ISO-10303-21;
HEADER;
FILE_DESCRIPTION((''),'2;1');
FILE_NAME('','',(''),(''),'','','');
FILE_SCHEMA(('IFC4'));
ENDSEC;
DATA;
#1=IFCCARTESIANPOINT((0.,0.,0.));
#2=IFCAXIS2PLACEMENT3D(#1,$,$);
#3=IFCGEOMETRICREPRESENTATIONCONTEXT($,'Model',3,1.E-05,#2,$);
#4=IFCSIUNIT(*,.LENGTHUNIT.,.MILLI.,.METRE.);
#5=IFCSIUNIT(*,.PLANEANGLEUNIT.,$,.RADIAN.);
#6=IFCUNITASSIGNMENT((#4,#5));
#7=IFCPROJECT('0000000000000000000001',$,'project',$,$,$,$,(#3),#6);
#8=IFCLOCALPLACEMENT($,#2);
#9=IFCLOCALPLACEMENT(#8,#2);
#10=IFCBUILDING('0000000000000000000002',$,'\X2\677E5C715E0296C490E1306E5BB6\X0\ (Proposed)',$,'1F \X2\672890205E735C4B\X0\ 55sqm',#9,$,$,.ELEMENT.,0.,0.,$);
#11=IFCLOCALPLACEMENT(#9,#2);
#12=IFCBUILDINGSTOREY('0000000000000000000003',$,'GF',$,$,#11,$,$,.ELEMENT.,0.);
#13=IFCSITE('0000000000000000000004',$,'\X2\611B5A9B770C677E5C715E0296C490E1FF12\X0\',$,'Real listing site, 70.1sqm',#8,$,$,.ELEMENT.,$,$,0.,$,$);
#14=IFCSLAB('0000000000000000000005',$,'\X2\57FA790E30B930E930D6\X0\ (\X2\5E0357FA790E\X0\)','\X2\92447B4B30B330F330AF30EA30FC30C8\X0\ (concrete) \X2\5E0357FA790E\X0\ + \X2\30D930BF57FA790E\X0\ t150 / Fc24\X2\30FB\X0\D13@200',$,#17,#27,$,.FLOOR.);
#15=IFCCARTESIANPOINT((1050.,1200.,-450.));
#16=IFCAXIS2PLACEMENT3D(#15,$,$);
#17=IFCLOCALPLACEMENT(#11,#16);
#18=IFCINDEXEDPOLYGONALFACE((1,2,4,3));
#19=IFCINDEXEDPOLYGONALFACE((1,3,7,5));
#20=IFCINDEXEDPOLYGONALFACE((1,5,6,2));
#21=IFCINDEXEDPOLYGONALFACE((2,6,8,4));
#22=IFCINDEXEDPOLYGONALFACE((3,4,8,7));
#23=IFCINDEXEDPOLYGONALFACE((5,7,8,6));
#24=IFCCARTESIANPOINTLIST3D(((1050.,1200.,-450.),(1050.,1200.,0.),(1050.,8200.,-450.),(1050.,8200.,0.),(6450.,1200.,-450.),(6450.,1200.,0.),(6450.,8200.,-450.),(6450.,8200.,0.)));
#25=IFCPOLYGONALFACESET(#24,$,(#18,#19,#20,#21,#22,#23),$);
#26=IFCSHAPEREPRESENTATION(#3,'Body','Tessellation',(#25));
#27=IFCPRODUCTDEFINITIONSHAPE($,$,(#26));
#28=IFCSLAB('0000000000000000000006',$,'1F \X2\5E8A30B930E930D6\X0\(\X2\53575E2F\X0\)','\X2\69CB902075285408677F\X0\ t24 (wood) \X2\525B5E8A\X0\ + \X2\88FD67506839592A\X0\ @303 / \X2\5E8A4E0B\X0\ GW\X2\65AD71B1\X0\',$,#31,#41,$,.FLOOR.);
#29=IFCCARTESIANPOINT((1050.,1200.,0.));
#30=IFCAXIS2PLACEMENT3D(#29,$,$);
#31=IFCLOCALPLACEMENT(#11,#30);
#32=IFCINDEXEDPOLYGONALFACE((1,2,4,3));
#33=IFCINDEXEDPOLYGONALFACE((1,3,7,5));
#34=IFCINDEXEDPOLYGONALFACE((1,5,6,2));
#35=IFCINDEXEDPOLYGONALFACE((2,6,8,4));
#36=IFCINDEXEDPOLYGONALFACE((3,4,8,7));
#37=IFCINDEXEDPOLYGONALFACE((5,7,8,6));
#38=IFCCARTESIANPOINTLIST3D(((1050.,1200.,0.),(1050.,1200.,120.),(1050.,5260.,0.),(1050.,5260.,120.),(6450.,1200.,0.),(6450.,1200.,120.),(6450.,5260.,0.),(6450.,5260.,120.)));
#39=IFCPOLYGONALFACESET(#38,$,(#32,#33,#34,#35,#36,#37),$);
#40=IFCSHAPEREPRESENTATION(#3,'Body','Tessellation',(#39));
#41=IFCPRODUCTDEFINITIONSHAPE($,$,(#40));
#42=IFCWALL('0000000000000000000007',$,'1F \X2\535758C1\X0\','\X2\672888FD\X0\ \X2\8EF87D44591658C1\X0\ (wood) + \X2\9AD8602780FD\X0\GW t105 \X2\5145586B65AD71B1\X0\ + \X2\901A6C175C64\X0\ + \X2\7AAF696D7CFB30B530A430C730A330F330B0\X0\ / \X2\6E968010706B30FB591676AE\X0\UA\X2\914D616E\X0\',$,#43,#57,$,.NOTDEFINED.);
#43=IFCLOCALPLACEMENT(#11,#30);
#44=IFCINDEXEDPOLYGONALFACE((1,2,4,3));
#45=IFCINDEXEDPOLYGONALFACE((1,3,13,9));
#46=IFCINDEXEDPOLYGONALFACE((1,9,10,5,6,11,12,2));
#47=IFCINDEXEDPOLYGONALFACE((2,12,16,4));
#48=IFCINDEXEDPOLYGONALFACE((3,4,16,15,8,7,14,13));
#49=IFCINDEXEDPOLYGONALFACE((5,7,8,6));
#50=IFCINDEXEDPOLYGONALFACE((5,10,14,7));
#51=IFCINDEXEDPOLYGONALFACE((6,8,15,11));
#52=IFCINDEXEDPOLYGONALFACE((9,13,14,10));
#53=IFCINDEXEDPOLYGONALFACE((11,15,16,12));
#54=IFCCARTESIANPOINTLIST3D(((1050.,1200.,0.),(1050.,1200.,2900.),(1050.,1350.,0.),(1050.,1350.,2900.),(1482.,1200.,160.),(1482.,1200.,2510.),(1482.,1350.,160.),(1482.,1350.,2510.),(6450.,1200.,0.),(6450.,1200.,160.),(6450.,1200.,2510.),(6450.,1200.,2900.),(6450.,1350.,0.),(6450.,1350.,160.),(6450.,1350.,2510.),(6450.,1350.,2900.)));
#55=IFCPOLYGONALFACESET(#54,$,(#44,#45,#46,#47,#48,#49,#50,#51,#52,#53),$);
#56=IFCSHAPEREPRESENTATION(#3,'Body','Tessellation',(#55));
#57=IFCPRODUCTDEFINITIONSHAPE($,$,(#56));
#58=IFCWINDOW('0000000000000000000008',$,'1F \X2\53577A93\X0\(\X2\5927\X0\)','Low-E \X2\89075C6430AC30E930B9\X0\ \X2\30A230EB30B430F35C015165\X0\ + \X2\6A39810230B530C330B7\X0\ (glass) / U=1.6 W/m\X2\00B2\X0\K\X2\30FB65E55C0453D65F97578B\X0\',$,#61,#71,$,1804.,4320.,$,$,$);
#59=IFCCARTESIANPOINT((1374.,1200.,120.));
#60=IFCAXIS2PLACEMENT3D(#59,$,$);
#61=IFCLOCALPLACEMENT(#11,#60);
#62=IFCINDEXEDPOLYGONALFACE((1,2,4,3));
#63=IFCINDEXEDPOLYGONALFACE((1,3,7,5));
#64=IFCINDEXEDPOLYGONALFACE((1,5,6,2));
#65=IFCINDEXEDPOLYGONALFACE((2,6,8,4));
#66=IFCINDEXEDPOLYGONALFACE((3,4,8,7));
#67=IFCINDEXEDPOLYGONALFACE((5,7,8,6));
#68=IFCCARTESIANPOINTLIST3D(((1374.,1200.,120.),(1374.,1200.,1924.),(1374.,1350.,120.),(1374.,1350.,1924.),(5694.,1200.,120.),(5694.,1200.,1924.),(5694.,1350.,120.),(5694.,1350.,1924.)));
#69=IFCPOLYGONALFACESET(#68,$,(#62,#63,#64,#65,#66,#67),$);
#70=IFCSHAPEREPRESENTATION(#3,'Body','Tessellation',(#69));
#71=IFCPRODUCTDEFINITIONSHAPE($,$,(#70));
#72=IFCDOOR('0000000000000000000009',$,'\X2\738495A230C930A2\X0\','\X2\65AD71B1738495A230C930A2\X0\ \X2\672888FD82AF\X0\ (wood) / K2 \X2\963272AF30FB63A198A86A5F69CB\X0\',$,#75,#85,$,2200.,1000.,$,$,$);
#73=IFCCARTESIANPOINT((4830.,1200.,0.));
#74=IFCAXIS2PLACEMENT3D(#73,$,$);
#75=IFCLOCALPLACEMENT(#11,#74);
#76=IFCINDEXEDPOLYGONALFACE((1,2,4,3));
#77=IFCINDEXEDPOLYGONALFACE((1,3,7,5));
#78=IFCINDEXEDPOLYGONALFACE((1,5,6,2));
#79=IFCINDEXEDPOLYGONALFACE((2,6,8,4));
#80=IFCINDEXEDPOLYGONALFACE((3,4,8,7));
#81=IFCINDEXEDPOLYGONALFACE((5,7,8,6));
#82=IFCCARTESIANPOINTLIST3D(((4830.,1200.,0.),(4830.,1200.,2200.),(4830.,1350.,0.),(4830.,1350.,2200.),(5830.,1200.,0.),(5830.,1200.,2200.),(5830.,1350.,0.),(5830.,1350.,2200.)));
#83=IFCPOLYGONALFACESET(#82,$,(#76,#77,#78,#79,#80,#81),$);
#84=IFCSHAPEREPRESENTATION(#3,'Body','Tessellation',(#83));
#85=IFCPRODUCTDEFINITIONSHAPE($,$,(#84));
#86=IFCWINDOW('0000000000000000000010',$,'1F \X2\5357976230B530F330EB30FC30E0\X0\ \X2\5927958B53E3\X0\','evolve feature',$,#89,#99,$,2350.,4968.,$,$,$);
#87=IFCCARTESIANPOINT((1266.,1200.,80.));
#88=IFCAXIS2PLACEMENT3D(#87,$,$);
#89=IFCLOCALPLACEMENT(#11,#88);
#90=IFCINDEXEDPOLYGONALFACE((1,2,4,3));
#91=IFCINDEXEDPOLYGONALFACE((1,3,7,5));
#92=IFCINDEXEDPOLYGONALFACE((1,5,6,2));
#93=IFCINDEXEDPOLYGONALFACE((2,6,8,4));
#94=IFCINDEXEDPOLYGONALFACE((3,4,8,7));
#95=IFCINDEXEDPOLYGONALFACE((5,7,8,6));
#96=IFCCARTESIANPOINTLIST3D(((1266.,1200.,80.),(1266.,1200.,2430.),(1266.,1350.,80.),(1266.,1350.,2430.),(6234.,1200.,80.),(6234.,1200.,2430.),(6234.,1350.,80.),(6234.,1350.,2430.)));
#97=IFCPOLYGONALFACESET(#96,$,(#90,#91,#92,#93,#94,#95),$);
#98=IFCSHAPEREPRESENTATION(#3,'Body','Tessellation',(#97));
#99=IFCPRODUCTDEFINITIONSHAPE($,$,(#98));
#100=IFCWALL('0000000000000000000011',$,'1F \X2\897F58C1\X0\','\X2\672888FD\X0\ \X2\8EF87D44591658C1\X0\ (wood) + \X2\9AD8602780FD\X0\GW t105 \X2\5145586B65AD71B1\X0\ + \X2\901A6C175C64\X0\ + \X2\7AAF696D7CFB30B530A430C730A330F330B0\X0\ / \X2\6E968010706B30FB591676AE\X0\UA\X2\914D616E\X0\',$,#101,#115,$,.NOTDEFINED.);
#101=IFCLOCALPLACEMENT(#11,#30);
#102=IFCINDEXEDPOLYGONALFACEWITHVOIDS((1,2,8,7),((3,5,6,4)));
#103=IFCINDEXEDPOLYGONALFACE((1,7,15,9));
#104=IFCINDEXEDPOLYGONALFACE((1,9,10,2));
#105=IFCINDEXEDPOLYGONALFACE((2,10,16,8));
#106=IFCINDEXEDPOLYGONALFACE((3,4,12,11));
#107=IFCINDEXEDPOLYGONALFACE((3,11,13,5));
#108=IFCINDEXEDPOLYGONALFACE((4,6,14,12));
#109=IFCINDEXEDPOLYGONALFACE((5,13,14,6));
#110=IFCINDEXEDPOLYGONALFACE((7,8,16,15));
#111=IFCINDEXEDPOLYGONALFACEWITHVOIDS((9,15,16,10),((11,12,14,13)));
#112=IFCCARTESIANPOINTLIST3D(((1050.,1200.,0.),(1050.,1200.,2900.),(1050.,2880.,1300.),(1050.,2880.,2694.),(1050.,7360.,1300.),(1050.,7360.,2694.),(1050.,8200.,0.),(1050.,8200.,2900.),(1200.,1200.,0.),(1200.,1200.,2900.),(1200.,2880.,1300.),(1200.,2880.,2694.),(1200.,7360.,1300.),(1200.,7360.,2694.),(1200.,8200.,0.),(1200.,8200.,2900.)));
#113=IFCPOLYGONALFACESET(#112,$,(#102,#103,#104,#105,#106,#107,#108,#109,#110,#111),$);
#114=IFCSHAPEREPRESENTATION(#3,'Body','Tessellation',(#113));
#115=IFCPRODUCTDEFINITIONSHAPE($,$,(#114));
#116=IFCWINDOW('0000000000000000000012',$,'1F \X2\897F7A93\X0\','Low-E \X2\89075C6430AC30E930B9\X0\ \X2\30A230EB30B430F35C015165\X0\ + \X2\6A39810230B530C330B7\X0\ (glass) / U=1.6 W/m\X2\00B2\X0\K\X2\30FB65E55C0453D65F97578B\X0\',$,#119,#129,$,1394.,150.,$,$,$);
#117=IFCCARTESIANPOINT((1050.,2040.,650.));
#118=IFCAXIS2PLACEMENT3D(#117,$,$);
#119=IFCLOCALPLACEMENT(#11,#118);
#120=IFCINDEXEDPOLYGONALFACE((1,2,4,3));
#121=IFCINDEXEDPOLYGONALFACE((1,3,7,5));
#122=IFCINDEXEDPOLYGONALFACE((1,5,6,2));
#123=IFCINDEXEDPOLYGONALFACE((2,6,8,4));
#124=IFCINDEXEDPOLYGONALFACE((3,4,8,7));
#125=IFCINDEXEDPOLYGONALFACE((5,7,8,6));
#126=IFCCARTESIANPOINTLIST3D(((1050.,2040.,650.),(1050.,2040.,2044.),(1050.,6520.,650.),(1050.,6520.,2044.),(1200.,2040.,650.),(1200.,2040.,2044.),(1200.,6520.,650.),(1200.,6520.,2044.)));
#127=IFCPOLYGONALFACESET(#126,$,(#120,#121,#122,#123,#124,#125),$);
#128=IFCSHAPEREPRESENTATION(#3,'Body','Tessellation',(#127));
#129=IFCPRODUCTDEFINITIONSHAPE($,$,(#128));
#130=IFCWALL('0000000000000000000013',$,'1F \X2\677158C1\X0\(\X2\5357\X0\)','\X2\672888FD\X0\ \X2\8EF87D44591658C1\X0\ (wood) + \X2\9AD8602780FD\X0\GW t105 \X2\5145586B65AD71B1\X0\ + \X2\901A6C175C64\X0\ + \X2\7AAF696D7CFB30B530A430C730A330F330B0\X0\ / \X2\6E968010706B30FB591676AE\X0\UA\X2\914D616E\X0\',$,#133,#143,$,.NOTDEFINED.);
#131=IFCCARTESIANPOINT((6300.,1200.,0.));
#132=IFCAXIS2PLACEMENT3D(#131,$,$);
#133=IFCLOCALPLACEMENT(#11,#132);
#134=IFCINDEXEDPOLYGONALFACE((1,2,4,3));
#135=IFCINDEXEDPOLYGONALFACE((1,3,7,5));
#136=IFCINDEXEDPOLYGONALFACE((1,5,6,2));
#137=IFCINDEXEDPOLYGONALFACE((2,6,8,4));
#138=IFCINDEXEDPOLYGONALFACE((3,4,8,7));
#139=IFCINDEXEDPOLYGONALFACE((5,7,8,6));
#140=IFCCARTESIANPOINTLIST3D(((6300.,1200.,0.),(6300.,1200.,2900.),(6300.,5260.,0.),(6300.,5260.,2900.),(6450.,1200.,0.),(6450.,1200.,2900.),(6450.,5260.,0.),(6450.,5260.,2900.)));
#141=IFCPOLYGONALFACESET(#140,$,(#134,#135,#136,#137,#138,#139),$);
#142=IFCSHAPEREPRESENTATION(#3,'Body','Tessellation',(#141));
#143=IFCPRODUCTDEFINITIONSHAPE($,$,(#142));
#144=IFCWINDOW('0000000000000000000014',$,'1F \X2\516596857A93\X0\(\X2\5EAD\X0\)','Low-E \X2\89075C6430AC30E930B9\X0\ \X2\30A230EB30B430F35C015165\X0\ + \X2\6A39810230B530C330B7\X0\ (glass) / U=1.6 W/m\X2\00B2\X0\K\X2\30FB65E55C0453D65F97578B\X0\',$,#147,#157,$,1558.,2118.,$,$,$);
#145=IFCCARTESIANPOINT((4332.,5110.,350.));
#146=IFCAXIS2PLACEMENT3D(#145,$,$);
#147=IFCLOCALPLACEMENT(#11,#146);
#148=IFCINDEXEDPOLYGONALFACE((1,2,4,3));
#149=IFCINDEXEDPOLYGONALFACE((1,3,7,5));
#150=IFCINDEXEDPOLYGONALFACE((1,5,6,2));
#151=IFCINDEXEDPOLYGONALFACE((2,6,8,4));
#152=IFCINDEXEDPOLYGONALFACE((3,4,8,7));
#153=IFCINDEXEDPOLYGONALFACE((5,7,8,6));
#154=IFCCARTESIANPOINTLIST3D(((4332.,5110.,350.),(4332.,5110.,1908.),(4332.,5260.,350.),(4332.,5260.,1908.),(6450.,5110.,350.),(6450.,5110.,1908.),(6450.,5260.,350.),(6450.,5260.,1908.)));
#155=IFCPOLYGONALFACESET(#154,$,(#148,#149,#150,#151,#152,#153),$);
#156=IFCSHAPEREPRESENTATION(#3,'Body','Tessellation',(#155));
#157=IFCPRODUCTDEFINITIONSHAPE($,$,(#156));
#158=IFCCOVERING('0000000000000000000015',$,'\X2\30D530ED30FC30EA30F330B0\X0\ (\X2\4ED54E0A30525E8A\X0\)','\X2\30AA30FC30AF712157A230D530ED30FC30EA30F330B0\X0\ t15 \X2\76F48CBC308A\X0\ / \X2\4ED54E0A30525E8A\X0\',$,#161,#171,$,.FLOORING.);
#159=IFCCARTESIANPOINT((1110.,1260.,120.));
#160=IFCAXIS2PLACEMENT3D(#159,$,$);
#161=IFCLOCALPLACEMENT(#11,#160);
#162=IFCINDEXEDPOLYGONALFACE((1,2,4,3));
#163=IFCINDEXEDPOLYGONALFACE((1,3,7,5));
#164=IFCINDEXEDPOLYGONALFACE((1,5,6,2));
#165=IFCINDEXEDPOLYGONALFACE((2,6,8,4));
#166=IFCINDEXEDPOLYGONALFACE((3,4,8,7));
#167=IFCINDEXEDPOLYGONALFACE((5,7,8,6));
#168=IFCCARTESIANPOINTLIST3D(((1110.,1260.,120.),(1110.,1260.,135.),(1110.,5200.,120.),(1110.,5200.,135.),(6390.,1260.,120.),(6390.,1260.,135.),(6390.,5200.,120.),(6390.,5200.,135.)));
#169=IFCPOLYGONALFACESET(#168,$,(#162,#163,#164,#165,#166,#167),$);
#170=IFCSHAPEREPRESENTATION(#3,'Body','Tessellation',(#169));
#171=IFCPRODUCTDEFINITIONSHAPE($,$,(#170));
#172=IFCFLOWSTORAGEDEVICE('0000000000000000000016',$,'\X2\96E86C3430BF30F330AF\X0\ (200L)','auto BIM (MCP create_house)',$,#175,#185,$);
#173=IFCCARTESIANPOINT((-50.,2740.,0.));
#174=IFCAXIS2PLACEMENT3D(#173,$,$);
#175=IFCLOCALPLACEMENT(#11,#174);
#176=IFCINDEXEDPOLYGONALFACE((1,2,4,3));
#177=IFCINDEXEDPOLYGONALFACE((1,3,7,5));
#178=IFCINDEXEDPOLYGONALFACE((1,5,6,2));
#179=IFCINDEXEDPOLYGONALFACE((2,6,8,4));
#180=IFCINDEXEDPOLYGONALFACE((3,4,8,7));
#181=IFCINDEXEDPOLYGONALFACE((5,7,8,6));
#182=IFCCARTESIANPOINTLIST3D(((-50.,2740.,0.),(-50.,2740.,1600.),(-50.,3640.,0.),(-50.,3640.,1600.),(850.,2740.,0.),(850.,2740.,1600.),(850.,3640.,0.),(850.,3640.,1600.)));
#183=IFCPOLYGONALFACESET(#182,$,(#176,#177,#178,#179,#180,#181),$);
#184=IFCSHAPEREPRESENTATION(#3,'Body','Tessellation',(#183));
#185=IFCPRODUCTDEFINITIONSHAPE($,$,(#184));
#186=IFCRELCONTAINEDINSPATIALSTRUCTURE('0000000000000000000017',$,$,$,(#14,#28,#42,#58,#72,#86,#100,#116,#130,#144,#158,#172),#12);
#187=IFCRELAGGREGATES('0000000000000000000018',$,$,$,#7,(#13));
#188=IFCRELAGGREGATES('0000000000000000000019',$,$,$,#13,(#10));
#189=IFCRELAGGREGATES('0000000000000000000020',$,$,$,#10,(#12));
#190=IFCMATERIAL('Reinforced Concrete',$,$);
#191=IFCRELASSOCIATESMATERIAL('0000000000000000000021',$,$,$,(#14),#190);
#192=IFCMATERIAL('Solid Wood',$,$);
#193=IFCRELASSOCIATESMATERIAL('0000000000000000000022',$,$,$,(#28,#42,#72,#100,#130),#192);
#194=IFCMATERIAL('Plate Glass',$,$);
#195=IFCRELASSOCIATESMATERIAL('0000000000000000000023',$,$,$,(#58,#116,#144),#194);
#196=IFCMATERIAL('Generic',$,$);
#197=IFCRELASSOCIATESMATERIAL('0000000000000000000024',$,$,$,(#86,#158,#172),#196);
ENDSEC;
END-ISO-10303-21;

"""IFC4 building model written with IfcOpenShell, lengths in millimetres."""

from ifc_helpers import new_model, si_unit, frame, frame_2d, origin, place, context, project, spatial, rectangle, extrude, material, element, fill, save


model = new_model("IFC4")

# Units and contexts
model_context = context("Model", 3, precision=1e-05, world=origin())
ifc_project = project(units=[si_unit("LENGTHUNIT", "METRE", prefix="MILLI"), si_unit("PLANEANGLEUNIT", "RADIAN")], contexts=[model_context])

# Site, building, storey
site_placement = place(None, origin())
site = spatial("IfcSite", under=ifc_project, at=site_placement, Name="愛媛県松山市雄郡２", ObjectType="Real listing site, 70.1sqm", CompositionType="ELEMENT", RefElevation=0.0)
building_placement = place(site_placement, origin())
building = spatial("IfcBuilding", under=site, at=building_placement, Name="松山市雄郡の家 (Proposed)", ObjectType="1F 木造平屋 55sqm", CompositionType="ELEMENT", ElevationOfRefHeight=0.0, ElevationOfTerrain=0.0)
storey_placement = place(building_placement, origin())
storey = spatial("IfcBuildingStorey", under=building, at=storey_placement, Name="GF", CompositionType="ELEMENT", Elevation=0.0)

# Slabs
ifc_material_1 = material(Name="Reinforced Concrete")
slab_1_placement = place(storey_placement, frame((1050.0, 1200.0, -450.0)))
element("IfcSlab", 1, at=slab_1_placement, inside=storey, material=ifc_material_1, Name="基礎スラブ (布基礎)", Description="鉄筋コンクリート (concrete) 布基礎 + ベタ基礎 t150 / Fc24・D13@200", PredefinedType="FLOOR", context=model_context, shape_type="SweptSolid", body=[
    extrude(rectangle(XDim=5400.0, YDim=7000.0, at=frame_2d((2700.0, 3500.0))), frame((1050.0, 1200.0, -450.0)), (0.0, 0.0, 1.0), 450.0),
])
ifc_material_2 = material(Name="Solid Wood")
slab_2_placement = place(storey_placement, frame((1050.0, 1200.0, 0.0)))
element("IfcSlab", 2, at=slab_2_placement, inside=storey, material=ifc_material_2, Name="1F 床スラブ(南帯)", Description="構造用合板 t24 (wood) 剛床 + 製材根太 @303 / 床下 GW断熱", PredefinedType="FLOOR", context=model_context, shape_type="SweptSolid", body=[
    extrude(rectangle(XDim=5400.0, YDim=4060.0, at=frame_2d((2700.0, 2030.0))), frame((1050.0, 1200.0, 0.0)), (0.0, 0.0, 1.0), 120.0),
])

# Wall, openings, windows, door
wall_1_placement = place(storey_placement, frame((1050.0, 1200.0, 0.0)))
wall_1 = element("IfcWall", 3, at=wall_1_placement, inside=storey, material=ifc_material_2, Name="1F 南壁", Description="木製 軸組外壁 (wood) + 高性能GW t105 充填断熱 + 通気層 + 窯業系サイディング / 準耐火・外皮UA配慮", PredefinedType="NOTDEFINED", context=model_context, shape_type="SweptSolid", body=[
    extrude(rectangle(XDim=5400.0, YDim=150.0, at=frame_2d((2700.0, 75.0))), frame((1050.0, 1200.0, 0.0)), (0.0, 0.0, 1.0), 2900.0),
])
opening_1_placement = place(storey_placement, frame((1374.0, 1200.0, 120.0)))
opening_1 = element("IfcOpeningElement", 4, at=opening_1_placement, cuts=wall_1, PredefinedType="NOTDEFINED", context=model_context, shape_type="SweptSolid", body=[
    extrude(rectangle(XDim=4320.0, YDim=150.0, at=frame_2d((2160.0, 75.0))), frame((1374.0, 1200.0, 120.0)), (0.0, 0.0, 1.0), 1804.0),
])
opening_2_placement = place(storey_placement, frame((4830.0, 1200.0, 0.0)))
opening_2 = element("IfcOpeningElement", 5, at=opening_2_placement, cuts=wall_1, PredefinedType="NOTDEFINED", context=model_context, shape_type="SweptSolid", body=[
    extrude(rectangle(XDim=1000.0, YDim=150.0, at=frame_2d((500.0, 75.0))), frame((4830.0, 1200.0, 0.0)), (0.0, 0.0, 1.0), 2200.0),
])
opening_3_placement = place(storey_placement, frame((1266.0, 1200.0, 80.0)))
opening_3 = element("IfcOpeningElement", 6, at=opening_3_placement, cuts=wall_1, PredefinedType="NOTDEFINED", context=model_context, shape_type="SweptSolid", body=[
    extrude(rectangle(XDim=4968.0, YDim=150.0, at=frame_2d((2484.0, 75.0))), frame((1266.0, 1200.0, 80.0)), (0.0, 0.0, 1.0), 2350.0),
])
ifc_material_3 = material(Name="Plate Glass")
window_1_placement = place(storey_placement, frame((1374.0, 1200.0, 120.0)))
window_1 = element("IfcWindow", 7, at=window_1_placement, inside=storey, material=ifc_material_3, Name="1F 南窓(大)", Description="Low-E 複層ガラス アルゴン封入 + 樹脂サッシ (glass) / U=1.6 W/m²K・日射取得型", OverallHeight=1804.0, OverallWidth=4320.0, context=model_context, shape_type="SweptSolid", body=[
    extrude(rectangle(XDim=4320.0, YDim=150.0, at=frame_2d((2160.0, 75.0))), frame((1374.0, 1200.0, 120.0)), (0.0, 0.0, 1.0), 1804.0),
])
fill(opening_1, window_1)
door_1_placement = place(storey_placement, frame((4830.0, 1200.0, 0.0)))
door_1 = element("IfcDoor", 8, at=door_1_placement, inside=storey, material=ifc_material_2, Name="玄関ドア", Description="断熱玄関ドア 木製芯 (wood) / K2 防犯・採風機構", OverallHeight=2200.0, OverallWidth=1000.0, context=model_context, shape_type="SweptSolid", body=[
    extrude(rectangle(XDim=1000.0, YDim=150.0, at=frame_2d((500.0, 75.0))), frame((4830.0, 1200.0, 0.0)), (0.0, 0.0, 1.0), 2200.0),
])
fill(opening_2, door_1)
ifc_material_4 = material(Name="Generic")
window_2_placement = place(storey_placement, frame((1266.0, 1200.0, 80.0)))
window_2 = element("IfcWindow", 9, at=window_2_placement, inside=storey, material=ifc_material_4, Name="1F 南面サンルーム 大開口", Description="evolve feature", OverallHeight=2350.0, OverallWidth=4968.0, context=model_context, shape_type="SweptSolid", body=[
    extrude(rectangle(XDim=4968.0, YDim=150.0, at=frame_2d((2484.0, 75.0))), frame((1266.0, 1200.0, 80.0)), (0.0, 0.0, 1.0), 2350.0),
])
fill(opening_3, window_2)

# Walls, openings, windows
wall_2_placement = place(storey_placement, frame((1050.0, 1200.0, 0.0)))
wall_2 = element("IfcWall", 10, at=wall_2_placement, inside=storey, material=ifc_material_2, Name="1F 西壁", Description="木製 軸組外壁 (wood) + 高性能GW t105 充填断熱 + 通気層 + 窯業系サイディング / 準耐火・外皮UA配慮", PredefinedType="NOTDEFINED", context=model_context, shape_type="SweptSolid", body=[
    extrude(rectangle(XDim=150.0, YDim=7000.0, at=frame_2d((75.0, 3500.0))), frame((1050.0, 1200.0, 0.0)), (0.0, 0.0, 1.0), 2900.0),
])
opening_4_placement = place(storey_placement, frame((1050.0, 2040.0, 650.0)))
opening_4 = element("IfcOpeningElement", 11, at=opening_4_placement, cuts=wall_2, PredefinedType="NOTDEFINED", context=model_context, shape_type="SweptSolid", body=[
    extrude(rectangle(XDim=150.0, YDim=4480.0, at=frame_2d((75.0, 2240.0))), frame((1050.0, 2040.0, 650.0)), (0.0, 0.0, 1.0), 1394.0),
])
window_3_placement = place(storey_placement, frame((1050.0, 2040.0, 650.0)))
window_3 = element("IfcWindow", 12, at=window_3_placement, inside=storey, material=ifc_material_3, Name="1F 西窓", Description="Low-E 複層ガラス アルゴン封入 + 樹脂サッシ (glass) / U=1.6 W/m²K・日射取得型", OverallHeight=1394.0, OverallWidth=150.0, context=model_context, shape_type="SweptSolid", body=[
    extrude(rectangle(XDim=150.0, YDim=4480.0, at=frame_2d((75.0, 2240.0))), frame((1050.0, 2040.0, 650.0)), (0.0, 0.0, 1.0), 1394.0),
])
fill(opening_4, window_3)
wall_3_placement = place(storey_placement, frame((6300.0, 1200.0, 0.0)))
wall_3 = element("IfcWall", 13, at=wall_3_placement, inside=storey, material=ifc_material_2, Name="1F 東壁(南)", Description="木製 軸組外壁 (wood) + 高性能GW t105 充填断熱 + 通気層 + 窯業系サイディング / 準耐火・外皮UA配慮", PredefinedType="NOTDEFINED", context=model_context, shape_type="SweptSolid", body=[
    extrude(rectangle(XDim=150.0, YDim=4060.0, at=frame_2d((75.0, 2030.0))), frame((6300.0, 1200.0, 0.0)), (0.0, 0.0, 1.0), 2900.0),
])
opening_5_placement = place(storey_placement, frame((4332.0, 5110.0, 350.0)))
opening_5 = element("IfcOpeningElement", 14, at=opening_5_placement, cuts=wall_3, PredefinedType="NOTDEFINED", context=model_context, shape_type="SweptSolid", body=[
    extrude(rectangle(XDim=2118.0, YDim=150.0, at=frame_2d((1059.0, 75.0))), frame((4332.0, 5110.0, 350.0)), (0.0, 0.0, 1.0), 1558.0),
])
window_4_placement = place(storey_placement, frame((4332.0, 5110.0, 350.0)))
window_4 = element("IfcWindow", 15, at=window_4_placement, inside=storey, material=ifc_material_3, Name="1F 入隅窓(庭)", Description="Low-E 複層ガラス アルゴン封入 + 樹脂サッシ (glass) / U=1.6 W/m²K・日射取得型", OverallHeight=1558.0, OverallWidth=2118.0, context=model_context, shape_type="SweptSolid", body=[
    extrude(rectangle(XDim=2118.0, YDim=150.0, at=frame_2d((1059.0, 75.0))), frame((4332.0, 5110.0, 350.0)), (0.0, 0.0, 1.0), 1558.0),
])
fill(opening_5, window_4)

# Covering
covering_placement = place(storey_placement, frame((1110.0, 1260.0, 120.0)))
element("IfcCovering", 16, at=covering_placement, inside=storey, material=ifc_material_4, Name="フローリング (仕上げ床)", Description="オーク無垢フローリング t15 直貼り / 仕上げ床", PredefinedType="FLOORING", context=model_context, shape_type="SweptSolid", body=[
    extrude(rectangle(XDim=5280.0, YDim=3940.0, at=frame_2d((2640.0, 1970.0))), frame((1110.0, 1260.0, 120.0)), (0.0, 0.0, 1.0), 15.0),
])

# Flow storage device
flow_storage_device_placement = place(storey_placement, frame((-50.0, 2740.0, 0.0)))
element("IfcFlowStorageDevice", 17, at=flow_storage_device_placement, inside=storey, material=ifc_material_4, Name="雨水タンク (200L)", Description="auto BIM (MCP create_house)", context=model_context, shape_type="SweptSolid", body=[
    extrude(rectangle(XDim=900.0, YDim=900.0, at=frame_2d((450.0, 450.0))), frame((-50.0, 2740.0, 0.0)), (0.0, 0.0, 1.0), 1600.0),
])

save(model, "model.ifc")
